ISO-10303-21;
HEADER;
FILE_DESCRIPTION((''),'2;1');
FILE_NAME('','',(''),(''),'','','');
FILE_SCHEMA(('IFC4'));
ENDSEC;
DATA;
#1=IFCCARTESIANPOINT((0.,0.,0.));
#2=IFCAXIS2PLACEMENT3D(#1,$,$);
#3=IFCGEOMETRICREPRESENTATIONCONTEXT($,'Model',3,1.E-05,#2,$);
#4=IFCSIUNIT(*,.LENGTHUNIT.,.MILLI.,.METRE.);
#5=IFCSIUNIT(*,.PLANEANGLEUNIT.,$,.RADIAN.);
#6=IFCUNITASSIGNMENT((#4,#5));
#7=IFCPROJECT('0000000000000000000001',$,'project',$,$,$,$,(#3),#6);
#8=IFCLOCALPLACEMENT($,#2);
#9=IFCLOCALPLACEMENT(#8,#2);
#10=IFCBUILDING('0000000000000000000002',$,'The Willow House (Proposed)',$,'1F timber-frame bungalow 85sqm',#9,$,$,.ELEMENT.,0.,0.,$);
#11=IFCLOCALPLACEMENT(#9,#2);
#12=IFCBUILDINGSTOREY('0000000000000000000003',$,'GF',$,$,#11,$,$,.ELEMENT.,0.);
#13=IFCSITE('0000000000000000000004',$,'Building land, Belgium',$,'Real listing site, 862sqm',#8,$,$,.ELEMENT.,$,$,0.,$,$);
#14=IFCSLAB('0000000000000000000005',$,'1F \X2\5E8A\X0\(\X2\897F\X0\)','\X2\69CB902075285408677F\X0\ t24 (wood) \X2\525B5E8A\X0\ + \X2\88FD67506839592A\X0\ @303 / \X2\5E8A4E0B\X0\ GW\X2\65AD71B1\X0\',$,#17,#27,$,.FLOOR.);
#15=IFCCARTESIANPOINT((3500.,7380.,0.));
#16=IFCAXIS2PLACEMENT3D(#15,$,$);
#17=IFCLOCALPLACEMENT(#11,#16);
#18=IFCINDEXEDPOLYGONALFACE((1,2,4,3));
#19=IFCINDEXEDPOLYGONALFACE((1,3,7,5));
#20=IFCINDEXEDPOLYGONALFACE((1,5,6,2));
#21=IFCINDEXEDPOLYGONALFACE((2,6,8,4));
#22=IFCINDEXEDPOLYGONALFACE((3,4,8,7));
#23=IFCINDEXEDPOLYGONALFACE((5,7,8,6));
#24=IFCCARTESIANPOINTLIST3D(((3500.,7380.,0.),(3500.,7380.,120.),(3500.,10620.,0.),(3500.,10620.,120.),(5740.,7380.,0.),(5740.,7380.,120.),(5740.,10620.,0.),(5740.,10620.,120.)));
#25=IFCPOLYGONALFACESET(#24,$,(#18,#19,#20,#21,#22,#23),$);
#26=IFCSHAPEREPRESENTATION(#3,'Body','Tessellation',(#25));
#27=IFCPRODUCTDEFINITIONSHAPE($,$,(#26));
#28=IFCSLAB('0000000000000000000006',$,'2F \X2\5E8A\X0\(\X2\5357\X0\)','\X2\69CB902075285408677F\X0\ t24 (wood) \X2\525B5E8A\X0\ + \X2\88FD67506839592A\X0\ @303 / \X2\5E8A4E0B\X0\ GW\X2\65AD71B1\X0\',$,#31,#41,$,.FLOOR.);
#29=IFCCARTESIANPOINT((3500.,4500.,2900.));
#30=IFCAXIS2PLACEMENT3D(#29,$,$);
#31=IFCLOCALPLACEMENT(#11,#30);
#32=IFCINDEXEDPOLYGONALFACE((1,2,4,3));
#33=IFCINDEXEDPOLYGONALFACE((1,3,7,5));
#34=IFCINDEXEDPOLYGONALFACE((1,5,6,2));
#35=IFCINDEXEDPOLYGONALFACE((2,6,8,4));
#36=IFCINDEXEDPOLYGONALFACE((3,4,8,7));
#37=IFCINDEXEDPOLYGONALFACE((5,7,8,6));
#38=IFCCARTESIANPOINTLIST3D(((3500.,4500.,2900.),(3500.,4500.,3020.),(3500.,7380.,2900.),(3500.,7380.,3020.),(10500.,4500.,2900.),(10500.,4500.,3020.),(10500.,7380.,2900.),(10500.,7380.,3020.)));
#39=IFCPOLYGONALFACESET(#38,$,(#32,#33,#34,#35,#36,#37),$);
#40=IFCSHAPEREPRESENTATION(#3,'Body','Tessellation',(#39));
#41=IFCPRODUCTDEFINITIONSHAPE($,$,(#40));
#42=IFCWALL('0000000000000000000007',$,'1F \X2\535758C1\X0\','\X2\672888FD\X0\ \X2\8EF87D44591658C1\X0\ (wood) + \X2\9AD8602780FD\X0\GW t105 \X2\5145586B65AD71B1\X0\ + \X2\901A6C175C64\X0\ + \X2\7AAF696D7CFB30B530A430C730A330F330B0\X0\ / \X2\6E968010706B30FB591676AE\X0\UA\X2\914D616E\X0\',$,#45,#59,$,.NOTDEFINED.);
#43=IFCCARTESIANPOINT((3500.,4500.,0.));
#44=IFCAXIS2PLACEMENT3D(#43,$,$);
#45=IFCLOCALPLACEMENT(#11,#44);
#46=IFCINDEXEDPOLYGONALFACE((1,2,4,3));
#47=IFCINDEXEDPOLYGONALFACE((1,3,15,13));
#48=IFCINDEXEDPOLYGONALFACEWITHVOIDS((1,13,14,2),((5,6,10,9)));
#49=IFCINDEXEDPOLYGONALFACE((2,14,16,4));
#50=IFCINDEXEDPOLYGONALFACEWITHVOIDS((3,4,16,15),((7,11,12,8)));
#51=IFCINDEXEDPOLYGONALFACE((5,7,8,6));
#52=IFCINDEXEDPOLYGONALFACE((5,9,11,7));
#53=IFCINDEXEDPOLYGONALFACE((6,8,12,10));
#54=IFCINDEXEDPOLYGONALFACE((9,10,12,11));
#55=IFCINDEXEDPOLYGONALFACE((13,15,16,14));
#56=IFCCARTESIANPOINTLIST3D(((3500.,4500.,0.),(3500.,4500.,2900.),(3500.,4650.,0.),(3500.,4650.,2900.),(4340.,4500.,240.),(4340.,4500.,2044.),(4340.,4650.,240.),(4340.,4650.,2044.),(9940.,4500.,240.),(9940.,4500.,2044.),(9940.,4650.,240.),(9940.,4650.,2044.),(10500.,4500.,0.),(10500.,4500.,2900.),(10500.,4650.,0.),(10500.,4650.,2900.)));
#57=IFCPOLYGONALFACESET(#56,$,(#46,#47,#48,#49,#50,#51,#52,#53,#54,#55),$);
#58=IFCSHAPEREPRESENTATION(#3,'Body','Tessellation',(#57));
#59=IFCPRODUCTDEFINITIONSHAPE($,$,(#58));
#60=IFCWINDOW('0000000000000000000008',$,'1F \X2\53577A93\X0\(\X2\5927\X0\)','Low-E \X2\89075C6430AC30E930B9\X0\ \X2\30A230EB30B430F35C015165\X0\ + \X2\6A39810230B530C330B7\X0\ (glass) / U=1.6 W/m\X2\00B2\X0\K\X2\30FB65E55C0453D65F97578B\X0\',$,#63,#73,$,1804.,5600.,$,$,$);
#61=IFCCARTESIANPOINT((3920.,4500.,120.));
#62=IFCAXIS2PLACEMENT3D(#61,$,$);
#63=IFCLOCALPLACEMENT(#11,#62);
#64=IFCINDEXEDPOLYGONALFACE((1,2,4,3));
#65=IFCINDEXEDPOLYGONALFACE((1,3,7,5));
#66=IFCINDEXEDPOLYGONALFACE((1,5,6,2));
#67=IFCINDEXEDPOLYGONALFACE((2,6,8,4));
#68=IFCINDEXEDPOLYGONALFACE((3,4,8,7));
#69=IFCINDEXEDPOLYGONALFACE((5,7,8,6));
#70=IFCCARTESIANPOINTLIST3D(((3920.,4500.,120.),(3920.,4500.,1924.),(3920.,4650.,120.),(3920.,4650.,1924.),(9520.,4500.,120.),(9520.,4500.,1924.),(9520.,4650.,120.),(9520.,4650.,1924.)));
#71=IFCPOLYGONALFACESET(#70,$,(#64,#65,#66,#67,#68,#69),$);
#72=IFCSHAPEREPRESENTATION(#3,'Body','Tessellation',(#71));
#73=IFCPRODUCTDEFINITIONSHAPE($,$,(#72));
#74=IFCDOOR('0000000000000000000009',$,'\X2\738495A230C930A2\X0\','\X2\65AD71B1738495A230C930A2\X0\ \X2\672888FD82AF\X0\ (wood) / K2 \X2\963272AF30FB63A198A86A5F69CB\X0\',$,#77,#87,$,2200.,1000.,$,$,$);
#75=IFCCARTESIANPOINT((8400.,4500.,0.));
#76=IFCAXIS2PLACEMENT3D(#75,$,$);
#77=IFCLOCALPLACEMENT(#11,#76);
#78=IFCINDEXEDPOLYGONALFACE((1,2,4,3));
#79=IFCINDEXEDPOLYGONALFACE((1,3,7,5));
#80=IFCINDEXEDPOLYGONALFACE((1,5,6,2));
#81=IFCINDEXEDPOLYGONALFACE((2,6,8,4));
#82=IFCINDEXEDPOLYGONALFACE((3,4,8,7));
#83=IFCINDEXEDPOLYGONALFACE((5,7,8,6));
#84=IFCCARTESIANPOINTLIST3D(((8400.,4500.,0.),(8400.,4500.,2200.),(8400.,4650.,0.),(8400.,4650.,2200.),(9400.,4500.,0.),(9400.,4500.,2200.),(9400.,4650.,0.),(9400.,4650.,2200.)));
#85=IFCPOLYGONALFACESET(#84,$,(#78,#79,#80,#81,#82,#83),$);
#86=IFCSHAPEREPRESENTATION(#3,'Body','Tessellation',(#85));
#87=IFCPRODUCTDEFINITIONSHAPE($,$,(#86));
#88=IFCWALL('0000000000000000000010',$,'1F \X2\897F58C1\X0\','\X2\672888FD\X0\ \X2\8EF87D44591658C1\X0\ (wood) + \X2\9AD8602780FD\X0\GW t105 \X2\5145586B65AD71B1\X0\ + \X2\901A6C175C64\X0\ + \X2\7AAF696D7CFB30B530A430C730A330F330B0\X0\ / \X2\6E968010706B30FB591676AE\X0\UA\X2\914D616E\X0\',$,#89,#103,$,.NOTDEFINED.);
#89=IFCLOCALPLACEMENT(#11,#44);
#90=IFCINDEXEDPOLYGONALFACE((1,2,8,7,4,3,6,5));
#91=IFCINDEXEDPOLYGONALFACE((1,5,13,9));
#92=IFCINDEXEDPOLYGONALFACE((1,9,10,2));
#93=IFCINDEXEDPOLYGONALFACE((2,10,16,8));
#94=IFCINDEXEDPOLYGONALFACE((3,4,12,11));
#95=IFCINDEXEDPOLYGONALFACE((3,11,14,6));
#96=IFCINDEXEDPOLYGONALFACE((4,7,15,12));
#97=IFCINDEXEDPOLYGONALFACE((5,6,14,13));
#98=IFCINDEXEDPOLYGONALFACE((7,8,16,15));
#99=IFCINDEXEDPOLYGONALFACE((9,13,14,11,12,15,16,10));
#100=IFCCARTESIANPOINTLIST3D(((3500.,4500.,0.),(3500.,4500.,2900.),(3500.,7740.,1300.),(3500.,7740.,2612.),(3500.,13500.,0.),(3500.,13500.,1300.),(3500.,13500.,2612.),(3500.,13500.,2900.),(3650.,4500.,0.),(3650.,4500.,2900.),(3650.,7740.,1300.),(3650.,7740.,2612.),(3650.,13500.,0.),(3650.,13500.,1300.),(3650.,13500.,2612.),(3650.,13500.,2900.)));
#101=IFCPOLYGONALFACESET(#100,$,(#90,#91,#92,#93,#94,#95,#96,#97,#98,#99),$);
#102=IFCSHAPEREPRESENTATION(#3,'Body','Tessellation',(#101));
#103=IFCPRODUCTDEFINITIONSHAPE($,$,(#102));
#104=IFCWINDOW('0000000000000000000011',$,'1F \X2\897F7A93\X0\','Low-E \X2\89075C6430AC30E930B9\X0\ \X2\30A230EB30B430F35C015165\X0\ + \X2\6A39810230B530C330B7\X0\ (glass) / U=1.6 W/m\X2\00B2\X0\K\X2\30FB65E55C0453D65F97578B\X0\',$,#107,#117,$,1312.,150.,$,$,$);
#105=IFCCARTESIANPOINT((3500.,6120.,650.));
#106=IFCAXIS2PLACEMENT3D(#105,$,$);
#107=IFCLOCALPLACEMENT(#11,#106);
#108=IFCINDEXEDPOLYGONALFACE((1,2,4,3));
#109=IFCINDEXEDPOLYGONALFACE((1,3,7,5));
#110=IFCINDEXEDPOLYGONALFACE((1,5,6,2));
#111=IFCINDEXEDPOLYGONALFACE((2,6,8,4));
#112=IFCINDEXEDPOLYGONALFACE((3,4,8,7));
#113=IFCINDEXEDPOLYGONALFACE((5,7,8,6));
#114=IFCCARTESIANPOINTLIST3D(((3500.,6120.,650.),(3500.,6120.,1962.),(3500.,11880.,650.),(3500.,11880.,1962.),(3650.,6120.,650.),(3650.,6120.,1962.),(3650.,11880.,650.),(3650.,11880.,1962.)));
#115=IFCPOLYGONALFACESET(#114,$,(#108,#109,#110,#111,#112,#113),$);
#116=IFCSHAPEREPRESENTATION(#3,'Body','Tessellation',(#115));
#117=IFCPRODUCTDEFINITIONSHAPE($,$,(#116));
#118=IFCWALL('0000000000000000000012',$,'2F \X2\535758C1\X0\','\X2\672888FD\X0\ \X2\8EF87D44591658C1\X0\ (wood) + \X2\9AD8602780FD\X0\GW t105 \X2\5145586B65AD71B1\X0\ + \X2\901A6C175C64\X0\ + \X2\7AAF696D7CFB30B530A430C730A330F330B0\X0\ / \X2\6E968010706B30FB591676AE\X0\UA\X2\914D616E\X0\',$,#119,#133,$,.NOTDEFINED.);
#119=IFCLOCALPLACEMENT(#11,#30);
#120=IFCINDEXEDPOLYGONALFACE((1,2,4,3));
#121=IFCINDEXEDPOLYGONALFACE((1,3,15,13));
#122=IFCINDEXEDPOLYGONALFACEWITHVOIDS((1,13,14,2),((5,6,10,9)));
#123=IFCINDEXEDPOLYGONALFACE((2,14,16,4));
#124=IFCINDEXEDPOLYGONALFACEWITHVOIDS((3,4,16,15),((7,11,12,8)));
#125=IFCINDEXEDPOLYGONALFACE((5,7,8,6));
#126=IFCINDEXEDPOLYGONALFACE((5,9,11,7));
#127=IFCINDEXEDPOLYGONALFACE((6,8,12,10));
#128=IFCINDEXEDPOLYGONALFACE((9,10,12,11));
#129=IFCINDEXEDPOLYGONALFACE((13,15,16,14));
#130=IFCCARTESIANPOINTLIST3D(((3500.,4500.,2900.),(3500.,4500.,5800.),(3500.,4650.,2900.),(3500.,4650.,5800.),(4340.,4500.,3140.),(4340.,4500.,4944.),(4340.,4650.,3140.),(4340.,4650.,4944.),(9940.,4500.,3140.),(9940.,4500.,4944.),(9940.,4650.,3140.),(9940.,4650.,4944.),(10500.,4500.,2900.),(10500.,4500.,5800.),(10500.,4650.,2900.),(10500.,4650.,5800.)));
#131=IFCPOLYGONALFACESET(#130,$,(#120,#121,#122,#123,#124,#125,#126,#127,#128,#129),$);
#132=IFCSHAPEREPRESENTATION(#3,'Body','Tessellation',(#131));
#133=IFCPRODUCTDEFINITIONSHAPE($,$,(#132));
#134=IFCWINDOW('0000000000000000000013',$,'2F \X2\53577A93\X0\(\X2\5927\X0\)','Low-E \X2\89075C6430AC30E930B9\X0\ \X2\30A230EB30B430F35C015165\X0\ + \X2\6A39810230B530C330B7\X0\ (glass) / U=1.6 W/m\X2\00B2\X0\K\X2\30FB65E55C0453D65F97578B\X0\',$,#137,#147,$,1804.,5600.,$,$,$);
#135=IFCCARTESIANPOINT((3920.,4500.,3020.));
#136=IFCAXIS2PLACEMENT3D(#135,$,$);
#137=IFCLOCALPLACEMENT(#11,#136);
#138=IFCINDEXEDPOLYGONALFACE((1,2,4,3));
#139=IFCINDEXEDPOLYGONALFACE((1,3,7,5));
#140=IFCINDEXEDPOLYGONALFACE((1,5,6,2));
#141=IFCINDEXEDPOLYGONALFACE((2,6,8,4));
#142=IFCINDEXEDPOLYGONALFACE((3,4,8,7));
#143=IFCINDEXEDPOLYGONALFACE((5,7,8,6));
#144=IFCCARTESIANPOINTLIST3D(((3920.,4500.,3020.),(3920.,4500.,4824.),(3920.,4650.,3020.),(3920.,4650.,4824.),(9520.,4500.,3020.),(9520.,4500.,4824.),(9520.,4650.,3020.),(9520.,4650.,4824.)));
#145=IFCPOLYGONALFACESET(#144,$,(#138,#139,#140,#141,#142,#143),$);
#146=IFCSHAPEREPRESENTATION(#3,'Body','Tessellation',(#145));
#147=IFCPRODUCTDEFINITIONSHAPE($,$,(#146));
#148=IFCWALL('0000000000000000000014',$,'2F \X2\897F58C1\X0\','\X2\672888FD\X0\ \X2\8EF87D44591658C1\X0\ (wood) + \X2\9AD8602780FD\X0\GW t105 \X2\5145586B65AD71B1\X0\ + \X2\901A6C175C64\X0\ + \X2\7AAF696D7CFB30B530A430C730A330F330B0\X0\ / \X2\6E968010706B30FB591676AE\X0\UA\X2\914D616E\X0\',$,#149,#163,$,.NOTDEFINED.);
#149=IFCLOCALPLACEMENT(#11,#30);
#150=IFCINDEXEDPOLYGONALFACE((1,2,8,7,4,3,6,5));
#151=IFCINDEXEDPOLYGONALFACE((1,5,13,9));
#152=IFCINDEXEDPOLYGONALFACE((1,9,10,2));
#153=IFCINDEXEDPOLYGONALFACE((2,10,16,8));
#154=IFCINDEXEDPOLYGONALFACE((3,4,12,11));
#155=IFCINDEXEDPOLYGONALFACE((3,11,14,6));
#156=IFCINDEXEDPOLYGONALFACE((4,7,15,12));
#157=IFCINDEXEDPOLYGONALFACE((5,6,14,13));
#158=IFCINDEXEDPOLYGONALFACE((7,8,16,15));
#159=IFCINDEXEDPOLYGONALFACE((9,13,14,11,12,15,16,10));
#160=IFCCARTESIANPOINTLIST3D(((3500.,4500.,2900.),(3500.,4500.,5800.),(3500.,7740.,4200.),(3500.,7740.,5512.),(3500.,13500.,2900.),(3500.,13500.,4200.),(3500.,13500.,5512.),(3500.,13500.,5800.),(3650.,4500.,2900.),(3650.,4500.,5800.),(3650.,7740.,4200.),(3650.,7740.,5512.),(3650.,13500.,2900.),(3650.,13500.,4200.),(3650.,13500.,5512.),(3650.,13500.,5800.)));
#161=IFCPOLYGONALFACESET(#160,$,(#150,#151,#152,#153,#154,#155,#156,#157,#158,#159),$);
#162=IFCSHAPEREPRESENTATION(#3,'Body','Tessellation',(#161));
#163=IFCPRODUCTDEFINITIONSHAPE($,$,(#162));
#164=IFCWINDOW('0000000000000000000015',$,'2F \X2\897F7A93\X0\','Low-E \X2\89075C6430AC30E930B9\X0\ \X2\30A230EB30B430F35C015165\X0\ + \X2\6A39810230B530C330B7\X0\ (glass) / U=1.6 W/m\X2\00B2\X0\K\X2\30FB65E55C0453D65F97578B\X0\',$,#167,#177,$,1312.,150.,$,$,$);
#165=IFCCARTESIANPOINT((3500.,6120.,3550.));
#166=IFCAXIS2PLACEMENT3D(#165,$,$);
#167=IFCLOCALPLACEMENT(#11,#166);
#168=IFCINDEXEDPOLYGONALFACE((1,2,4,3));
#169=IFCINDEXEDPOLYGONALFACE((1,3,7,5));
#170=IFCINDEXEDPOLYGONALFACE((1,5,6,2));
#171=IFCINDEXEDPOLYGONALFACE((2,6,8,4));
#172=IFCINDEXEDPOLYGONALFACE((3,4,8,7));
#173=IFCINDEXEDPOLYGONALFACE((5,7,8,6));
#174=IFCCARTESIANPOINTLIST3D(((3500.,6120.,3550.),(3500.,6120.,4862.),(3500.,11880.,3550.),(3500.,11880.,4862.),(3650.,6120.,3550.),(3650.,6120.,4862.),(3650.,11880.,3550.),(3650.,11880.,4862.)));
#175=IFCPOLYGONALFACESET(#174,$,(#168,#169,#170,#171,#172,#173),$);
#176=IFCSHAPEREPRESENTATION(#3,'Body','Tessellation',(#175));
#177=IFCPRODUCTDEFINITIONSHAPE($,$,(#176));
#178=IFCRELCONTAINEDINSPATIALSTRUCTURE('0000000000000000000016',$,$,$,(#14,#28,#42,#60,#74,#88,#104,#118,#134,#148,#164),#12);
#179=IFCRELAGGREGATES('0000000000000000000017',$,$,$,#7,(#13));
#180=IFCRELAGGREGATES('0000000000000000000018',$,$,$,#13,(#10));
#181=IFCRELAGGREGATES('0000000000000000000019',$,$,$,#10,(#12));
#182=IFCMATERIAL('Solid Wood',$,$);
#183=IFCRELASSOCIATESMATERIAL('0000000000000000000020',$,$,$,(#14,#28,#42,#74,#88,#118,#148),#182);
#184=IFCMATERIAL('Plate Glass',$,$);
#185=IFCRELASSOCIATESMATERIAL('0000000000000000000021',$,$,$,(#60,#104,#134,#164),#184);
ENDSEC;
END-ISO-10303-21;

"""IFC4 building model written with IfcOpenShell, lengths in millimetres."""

from ifc_helpers import new_model, si_unit, frame, frame_2d, origin, place, context, project, spatial, rectangle, extrude, material, element, fill, save


model = new_model("IFC4")

# Units and contexts
model_context = context("Model", 3, precision=1e-05, world=origin())
ifc_project = project(units=[si_unit("LENGTHUNIT", "METRE", prefix="MILLI"), si_unit("PLANEANGLEUNIT", "RADIAN")], contexts=[model_context])

# Site, building, storey
site_placement = place(None, origin())
site = spatial("IfcSite", under=ifc_project, at=site_placement, Name="Building land, Belgium", ObjectType="Real listing site, 862sqm", CompositionType="ELEMENT", RefElevation=0.0)
building_placement = place(site_placement, origin())
building = spatial("IfcBuilding", under=site, at=building_placement, Name="The Willow House (Proposed)", ObjectType="1F timber-frame bungalow 85sqm", CompositionType="ELEMENT", ElevationOfRefHeight=0.0, ElevationOfTerrain=0.0)
storey_placement = place(building_placement, origin())
storey = spatial("IfcBuildingStorey", under=building, at=storey_placement, Name="GF", CompositionType="ELEMENT", Elevation=0.0)

# Slabs
ifc_material_1 = material(Name="Solid Wood")
slab_1_placement = place(storey_placement, frame((3500.0, 7380.0, 0.0)))
element("IfcSlab", 1, at=slab_1_placement, inside=storey, material=ifc_material_1, Name="1F 床(西)", Description="構造用合板 t24 (wood) 剛床 + 製材根太 @303 / 床下 GW断熱", PredefinedType="FLOOR", context=model_context, shape_type="SweptSolid", body=[
    extrude(rectangle(XDim=2240.0, YDim=3240.0, at=frame_2d((1120.0, 1620.0))), frame((3500.0, 7380.0, 0.0)), (0.0, 0.0, 1.0), 120.0),
])
slab_2_placement = place(storey_placement, frame((3500.0, 4500.0, 2900.0)))
element("IfcSlab", 2, at=slab_2_placement, inside=storey, material=ifc_material_1, Name="2F 床(南)", Description="構造用合板 t24 (wood) 剛床 + 製材根太 @303 / 床下 GW断熱", PredefinedType="FLOOR", context=model_context, shape_type="SweptSolid", body=[
    extrude(rectangle(XDim=7000.0, YDim=2880.0, at=frame_2d((3500.0, 1440.0))), frame((3500.0, 4500.0, 2900.0)), (0.0, 0.0, 1.0), 120.0),
])

# Wall, openings, window, door
wall_1_placement = place(storey_placement, frame((3500.0, 4500.0, 0.0)))
wall_1 = element("IfcWall", 3, at=wall_1_placement, inside=storey, material=ifc_material_1, Name="1F 南壁", Description="木製 軸組外壁 (wood) + 高性能GW t105 充填断熱 + 通気層 + 窯業系サイディング / 準耐火・外皮UA配慮", PredefinedType="NOTDEFINED", context=model_context, shape_type="SweptSolid", body=[
    extrude(rectangle(XDim=7000.0, YDim=150.0, at=frame_2d((3500.0, 75.0))), frame((3500.0, 4500.0, 0.0)), (0.0, 0.0, 1.0), 2900.0),
])
opening_1_placement = place(storey_placement, frame((3920.0, 4500.0, 120.0)))
opening_1 = element("IfcOpeningElement", 4, at=opening_1_placement, cuts=wall_1, PredefinedType="NOTDEFINED", context=model_context, shape_type="SweptSolid", body=[
    extrude(rectangle(XDim=5600.0, YDim=150.0, at=frame_2d((2800.0, 75.0))), frame((3920.0, 4500.0, 120.0)), (0.0, 0.0, 1.0), 1804.0),
])
opening_2_placement = place(storey_placement, frame((8400.0, 4500.0, 0.0)))
opening_2 = element("IfcOpeningElement", 5, at=opening_2_placement, cuts=wall_1, PredefinedType="NOTDEFINED", context=model_context, shape_type="SweptSolid", body=[
    extrude(rectangle(XDim=1000.0, YDim=150.0, at=frame_2d((500.0, 75.0))), frame((8400.0, 4500.0, 0.0)), (0.0, 0.0, 1.0), 2200.0),
])
ifc_material_2 = material(Name="Plate Glass")
window_1_placement = place(storey_placement, frame((3920.0, 4500.0, 120.0)))
window_1 = element("IfcWindow", 6, at=window_1_placement, inside=storey, material=ifc_material_2, Name="1F 南窓(大)", Description="Low-E 複層ガラス アルゴン封入 + 樹脂サッシ (glass) / U=1.6 W/m²K・日射取得型", OverallHeight=1804.0, OverallWidth=5600.0, context=model_context, shape_type="SweptSolid", body=[
    extrude(rectangle(XDim=5600.0, YDim=150.0, at=frame_2d((2800.0, 75.0))), frame((3920.0, 4500.0, 120.0)), (0.0, 0.0, 1.0), 1804.0),
])
fill(opening_1, window_1)
door_placement = place(storey_placement, frame((8400.0, 4500.0, 0.0)))
door = element("IfcDoor", 7, at=door_placement, inside=storey, material=ifc_material_1, Name="玄関ドア", Description="断熱玄関ドア 木製芯 (wood) / K2 防犯・採風機構", OverallHeight=2200.0, OverallWidth=1000.0, context=model_context, shape_type="SweptSolid", body=[
    extrude(rectangle(XDim=1000.0, YDim=150.0, at=frame_2d((500.0, 75.0))), frame((8400.0, 4500.0, 0.0)), (0.0, 0.0, 1.0), 2200.0),
])
fill(opening_2, door)

# Walls, openings, windows
wall_2_placement = place(storey_placement, frame((3500.0, 4500.0, 0.0)))
wall_2 = element("IfcWall", 8, at=wall_2_placement, inside=storey, material=ifc_material_1, Name="1F 西壁", Description="木製 軸組外壁 (wood) + 高性能GW t105 充填断熱 + 通気層 + 窯業系サイディング / 準耐火・外皮UA配慮", PredefinedType="NOTDEFINED", context=model_context, shape_type="SweptSolid", body=[
    extrude(rectangle(XDim=150.0, YDim=9000.0, at=frame_2d((75.0, 4500.0))), frame((3500.0, 4500.0, 0.0)), (0.0, 0.0, 1.0), 2900.0),
])
opening_3_placement = place(storey_placement, frame((3500.0, 6120.0, 650.0)))
opening_3 = element("IfcOpeningElement", 9, at=opening_3_placement, cuts=wall_2, PredefinedType="NOTDEFINED", context=model_context, shape_type="SweptSolid", body=[
    extrude(rectangle(XDim=150.0, YDim=5760.0, at=frame_2d((75.0, 2880.0))), frame((3500.0, 6120.0, 650.0)), (0.0, 0.0, 1.0), 1312.0),
])
window_2_placement = place(storey_placement, frame((3500.0, 6120.0, 650.0)))
window_2 = element("IfcWindow", 10, at=window_2_placement, inside=storey, material=ifc_material_2, Name="1F 西窓", Description="Low-E 複層ガラス アルゴン封入 + 樹脂サッシ (glass) / U=1.6 W/m²K・日射取得型", OverallHeight=1312.0, OverallWidth=150.0, context=model_context, shape_type="SweptSolid", body=[
    extrude(rectangle(XDim=150.0, YDim=5760.0, at=frame_2d((75.0, 2880.0))), frame((3500.0, 6120.0, 650.0)), (0.0, 0.0, 1.0), 1312.0),
])
fill(opening_3, window_2)
wall_3_placement = place(storey_placement, frame((3500.0, 4500.0, 2900.0)))
wall_3 = element("IfcWall", 11, at=wall_3_placement, inside=storey, material=ifc_material_1, Name="2F 南壁", Description="木製 軸組外壁 (wood) + 高性能GW t105 充填断熱 + 通気層 + 窯業系サイディング / 準耐火・外皮UA配慮", PredefinedType="NOTDEFINED", context=model_context, shape_type="SweptSolid", body=[
    extrude(rectangle(XDim=7000.0, YDim=150.0, at=frame_2d((3500.0, 75.0))), frame((3500.0, 4500.0, 2900.0)), (0.0, 0.0, 1.0), 2900.0),
])
opening_4_placement = place(storey_placement, frame((3920.0, 4500.0, 3020.0)))
opening_4 = element("IfcOpeningElement", 12, at=opening_4_placement, cuts=wall_3, PredefinedType="NOTDEFINED", context=model_context, shape_type="SweptSolid", body=[
    extrude(rectangle(XDim=5600.0, YDim=150.0, at=frame_2d((2800.0, 75.0))), frame((3920.0, 4500.0, 3020.0)), (0.0, 0.0, 1.0), 1804.0),
])
window_3_placement = place(storey_placement, frame((3920.0, 4500.0, 3020.0)))
window_3 = element("IfcWindow", 13, at=window_3_placement, inside=storey, material=ifc_material_2, Name="2F 南窓(大)", Description="Low-E 複層ガラス アルゴン封入 + 樹脂サッシ (glass) / U=1.6 W/m²K・日射取得型", OverallHeight=1804.0, OverallWidth=5600.0, context=model_context, shape_type="SweptSolid", body=[
    extrude(rectangle(XDim=5600.0, YDim=150.0, at=frame_2d((2800.0, 75.0))), frame((3920.0, 4500.0, 3020.0)), (0.0, 0.0, 1.0), 1804.0),
])
fill(opening_4, window_3)
wall_4_placement = place(storey_placement, frame((3500.0, 4500.0, 2900.0)))
wall_4 = element("IfcWall", 14, at=wall_4_placement, inside=storey, material=ifc_material_1, Name="2F 西壁", Description="木製 軸組外壁 (wood) + 高性能GW t105 充填断熱 + 通気層 + 窯業系サイディング / 準耐火・外皮UA配慮", PredefinedType="NOTDEFINED", context=model_context, shape_type="SweptSolid", body=[
    extrude(rectangle(XDim=150.0, YDim=9000.0, at=frame_2d((75.0, 4500.0))), frame((3500.0, 4500.0, 2900.0)), (0.0, 0.0, 1.0), 2900.0),
])
opening_5_placement = place(storey_placement, frame((3500.0, 6120.0, 3550.0)))
opening_5 = element("IfcOpeningElement", 15, at=opening_5_placement, cuts=wall_4, PredefinedType="NOTDEFINED", context=model_context, shape_type="SweptSolid", body=[
    extrude(rectangle(XDim=150.0, YDim=5760.0, at=frame_2d((75.0, 2880.0))), frame((3500.0, 6120.0, 3550.0)), (0.0, 0.0, 1.0), 1312.0),
])
window_4_placement = place(storey_placement, frame((3500.0, 6120.0, 3550.0)))
window_4 = element("IfcWindow", 16, at=window_4_placement, inside=storey, material=ifc_material_2, Name="2F 西窓", Description="Low-E 複層ガラス アルゴン封入 + 樹脂サッシ (glass) / U=1.6 W/m²K・日射取得型", OverallHeight=1312.0, OverallWidth=150.0, context=model_context, shape_type="SweptSolid", body=[
    extrude(rectangle(XDim=150.0, YDim=5760.0, at=frame_2d((75.0, 2880.0))), frame((3500.0, 6120.0, 3550.0)), (0.0, 0.0, 1.0), 1312.0),
])
fill(opening_5, window_4)

save(model, "model.ifc")
